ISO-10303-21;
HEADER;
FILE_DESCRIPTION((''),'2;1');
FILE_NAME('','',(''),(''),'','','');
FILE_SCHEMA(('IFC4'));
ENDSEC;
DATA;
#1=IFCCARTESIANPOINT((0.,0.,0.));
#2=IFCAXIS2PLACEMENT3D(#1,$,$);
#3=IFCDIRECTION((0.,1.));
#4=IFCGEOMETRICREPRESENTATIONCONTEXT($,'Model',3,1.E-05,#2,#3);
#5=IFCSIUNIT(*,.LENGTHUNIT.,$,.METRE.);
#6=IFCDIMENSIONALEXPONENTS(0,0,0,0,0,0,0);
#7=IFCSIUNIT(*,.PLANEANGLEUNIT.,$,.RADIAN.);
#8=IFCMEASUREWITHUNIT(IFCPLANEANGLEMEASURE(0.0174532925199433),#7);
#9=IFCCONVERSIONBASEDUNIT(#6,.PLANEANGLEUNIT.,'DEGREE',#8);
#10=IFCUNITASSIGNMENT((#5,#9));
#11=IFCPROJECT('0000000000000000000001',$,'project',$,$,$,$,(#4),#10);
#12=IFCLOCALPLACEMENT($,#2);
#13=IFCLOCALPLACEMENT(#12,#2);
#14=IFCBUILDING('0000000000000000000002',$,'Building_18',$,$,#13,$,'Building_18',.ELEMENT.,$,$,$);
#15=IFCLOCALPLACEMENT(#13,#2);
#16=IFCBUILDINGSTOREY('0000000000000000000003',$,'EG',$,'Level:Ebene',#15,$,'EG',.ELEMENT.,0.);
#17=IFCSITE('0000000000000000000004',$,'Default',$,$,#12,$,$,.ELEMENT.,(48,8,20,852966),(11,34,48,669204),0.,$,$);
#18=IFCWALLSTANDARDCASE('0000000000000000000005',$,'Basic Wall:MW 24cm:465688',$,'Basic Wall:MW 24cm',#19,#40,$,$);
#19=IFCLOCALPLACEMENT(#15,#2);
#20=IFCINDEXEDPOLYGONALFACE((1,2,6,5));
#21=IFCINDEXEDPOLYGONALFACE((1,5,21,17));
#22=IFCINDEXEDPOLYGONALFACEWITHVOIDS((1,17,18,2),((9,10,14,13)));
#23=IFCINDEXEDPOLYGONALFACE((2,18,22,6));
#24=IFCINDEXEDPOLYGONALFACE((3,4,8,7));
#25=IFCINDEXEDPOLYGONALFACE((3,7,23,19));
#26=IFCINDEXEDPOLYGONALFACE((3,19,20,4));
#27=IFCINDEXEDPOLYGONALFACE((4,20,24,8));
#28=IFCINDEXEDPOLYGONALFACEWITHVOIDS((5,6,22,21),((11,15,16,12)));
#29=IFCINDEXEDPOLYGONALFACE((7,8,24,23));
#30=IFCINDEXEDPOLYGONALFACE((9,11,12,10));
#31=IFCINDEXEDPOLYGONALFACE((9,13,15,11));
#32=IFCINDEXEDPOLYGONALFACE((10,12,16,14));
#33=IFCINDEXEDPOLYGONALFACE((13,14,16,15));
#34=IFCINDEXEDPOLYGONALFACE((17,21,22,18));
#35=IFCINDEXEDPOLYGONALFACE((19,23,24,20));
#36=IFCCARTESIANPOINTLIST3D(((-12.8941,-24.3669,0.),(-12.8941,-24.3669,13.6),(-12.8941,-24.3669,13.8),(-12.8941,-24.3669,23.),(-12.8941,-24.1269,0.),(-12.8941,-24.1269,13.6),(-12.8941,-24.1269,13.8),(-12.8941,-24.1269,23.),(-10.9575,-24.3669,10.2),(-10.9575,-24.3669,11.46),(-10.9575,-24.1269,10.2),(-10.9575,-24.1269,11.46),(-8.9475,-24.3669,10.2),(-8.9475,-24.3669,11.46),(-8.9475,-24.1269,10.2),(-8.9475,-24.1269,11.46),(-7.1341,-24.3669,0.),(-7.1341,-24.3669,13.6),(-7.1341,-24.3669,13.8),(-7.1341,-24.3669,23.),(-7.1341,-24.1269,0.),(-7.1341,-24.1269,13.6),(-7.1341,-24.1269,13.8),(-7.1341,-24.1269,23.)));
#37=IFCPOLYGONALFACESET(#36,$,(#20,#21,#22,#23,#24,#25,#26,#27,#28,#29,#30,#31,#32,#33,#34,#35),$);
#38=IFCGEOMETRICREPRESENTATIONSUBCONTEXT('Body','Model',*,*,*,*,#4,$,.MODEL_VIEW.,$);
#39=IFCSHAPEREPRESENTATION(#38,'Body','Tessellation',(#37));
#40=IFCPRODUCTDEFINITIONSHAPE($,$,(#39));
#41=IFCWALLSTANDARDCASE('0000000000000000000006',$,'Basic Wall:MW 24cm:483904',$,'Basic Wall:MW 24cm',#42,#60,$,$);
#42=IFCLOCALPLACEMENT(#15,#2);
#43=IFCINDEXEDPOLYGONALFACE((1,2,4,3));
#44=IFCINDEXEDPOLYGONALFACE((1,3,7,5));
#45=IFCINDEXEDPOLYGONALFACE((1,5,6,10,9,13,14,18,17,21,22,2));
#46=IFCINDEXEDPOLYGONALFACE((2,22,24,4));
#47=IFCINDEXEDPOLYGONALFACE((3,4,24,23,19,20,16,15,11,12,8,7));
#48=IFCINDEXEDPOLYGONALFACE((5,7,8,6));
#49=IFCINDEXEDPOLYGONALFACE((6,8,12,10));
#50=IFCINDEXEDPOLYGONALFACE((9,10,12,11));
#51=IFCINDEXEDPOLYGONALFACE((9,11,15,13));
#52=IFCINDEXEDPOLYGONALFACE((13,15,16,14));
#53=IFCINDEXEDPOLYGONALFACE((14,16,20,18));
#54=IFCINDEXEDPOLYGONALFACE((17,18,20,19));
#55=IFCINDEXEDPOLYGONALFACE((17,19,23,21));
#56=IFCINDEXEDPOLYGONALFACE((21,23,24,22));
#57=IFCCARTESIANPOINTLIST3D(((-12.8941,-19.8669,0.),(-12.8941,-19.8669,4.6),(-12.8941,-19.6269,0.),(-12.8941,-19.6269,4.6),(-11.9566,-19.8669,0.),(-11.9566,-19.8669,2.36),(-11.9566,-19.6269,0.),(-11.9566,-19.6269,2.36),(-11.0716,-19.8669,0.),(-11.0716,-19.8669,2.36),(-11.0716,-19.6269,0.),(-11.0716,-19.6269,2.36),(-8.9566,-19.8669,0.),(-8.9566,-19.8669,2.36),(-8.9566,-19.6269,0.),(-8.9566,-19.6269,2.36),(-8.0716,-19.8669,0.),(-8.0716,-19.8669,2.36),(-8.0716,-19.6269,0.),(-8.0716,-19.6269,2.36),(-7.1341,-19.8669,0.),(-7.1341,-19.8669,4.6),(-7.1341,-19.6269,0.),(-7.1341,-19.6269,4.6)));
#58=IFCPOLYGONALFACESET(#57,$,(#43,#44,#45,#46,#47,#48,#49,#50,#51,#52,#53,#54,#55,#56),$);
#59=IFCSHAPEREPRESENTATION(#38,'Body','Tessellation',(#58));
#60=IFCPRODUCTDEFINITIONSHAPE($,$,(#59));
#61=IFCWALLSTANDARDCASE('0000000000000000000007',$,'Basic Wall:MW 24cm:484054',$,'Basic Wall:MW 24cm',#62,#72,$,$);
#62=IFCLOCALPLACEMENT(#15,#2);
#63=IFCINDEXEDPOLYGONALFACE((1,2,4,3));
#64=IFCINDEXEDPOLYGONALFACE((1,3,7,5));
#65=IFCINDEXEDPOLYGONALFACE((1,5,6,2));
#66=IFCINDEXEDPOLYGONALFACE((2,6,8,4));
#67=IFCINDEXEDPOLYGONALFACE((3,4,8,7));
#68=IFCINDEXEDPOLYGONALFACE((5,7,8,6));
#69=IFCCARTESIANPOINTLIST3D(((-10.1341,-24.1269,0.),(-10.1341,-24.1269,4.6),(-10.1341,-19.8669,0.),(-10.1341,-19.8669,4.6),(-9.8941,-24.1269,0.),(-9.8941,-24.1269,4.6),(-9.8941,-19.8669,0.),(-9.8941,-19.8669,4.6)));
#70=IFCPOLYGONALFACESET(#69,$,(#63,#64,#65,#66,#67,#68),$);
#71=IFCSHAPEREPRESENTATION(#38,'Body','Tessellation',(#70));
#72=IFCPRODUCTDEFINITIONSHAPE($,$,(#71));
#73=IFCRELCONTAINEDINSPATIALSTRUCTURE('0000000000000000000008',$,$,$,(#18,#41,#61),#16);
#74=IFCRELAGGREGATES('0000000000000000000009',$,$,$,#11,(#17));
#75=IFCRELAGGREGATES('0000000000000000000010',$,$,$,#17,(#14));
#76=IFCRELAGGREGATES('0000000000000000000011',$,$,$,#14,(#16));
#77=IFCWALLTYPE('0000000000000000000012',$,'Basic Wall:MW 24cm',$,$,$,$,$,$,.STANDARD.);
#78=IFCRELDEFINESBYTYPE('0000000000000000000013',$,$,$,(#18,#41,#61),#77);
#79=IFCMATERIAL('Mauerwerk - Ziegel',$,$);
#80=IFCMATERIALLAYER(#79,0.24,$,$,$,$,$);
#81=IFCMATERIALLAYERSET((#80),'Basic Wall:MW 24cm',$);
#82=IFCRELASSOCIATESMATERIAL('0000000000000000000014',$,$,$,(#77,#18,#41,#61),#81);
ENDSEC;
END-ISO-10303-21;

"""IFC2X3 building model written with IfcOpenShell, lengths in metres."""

from ifc_helpers import new_model, entity, si_unit, converted_unit, direction, frame, frame_2d, origin, place, context, subcontext, project, spatial, rectangle, extrude, material, layer, layer_set, layer_usage, type_object, element, save


model = new_model("IFC2X3")

# Units and contexts
model_context = context("Model", 3, precision=1e-05, world=origin(), true_north=direction((0.0, 1.0)))
body_context = subcontext(model_context, "Body", "Model", "MODEL_VIEW")
ifc_project = project(units=[si_unit("LENGTHUNIT", "METRE"), converted_unit("PLANEANGLEUNIT", "DEGREE", entity("IfcPlaneAngleMeasure", 0.0174532925199433), si_unit("PLANEANGLEUNIT", "RADIAN"), dimensions=[0, 0, 0, 0, 0, 0, 0])], contexts=[model_context])

# Site, building, storey
site_placement = place(None, origin())
site = spatial("IfcSite", under=ifc_project, at=site_placement, Name="Default", CompositionType="ELEMENT", RefLatitude=(48, 8, 20, 852966), RefLongitude=(11, 34, 48, 669204), RefElevation=0.0)
building_placement = place(site_placement, origin())
building = spatial("IfcBuilding", under=site, at=building_placement, Name="Building_18", LongName="Building_18", CompositionType="ELEMENT")
storey_placement = place(building_placement, origin())
storey = spatial("IfcBuildingStorey", under=building, at=storey_placement, Name="EG", ObjectType="Level:Ebene", LongName="EG", CompositionType="ELEMENT", Elevation=0.0)

# Walls, openings
ifc_material_1 = material(Name="Mauerwerk - Ziegel")
ifc_layer = layer(ifc_material_1, 0.24)
ifc_layer_set = layer_set([ifc_layer], Name="Basic Wall:MW 24cm")
wall_type = type_object("IfcWallType", Name="Basic Wall:MW 24cm", PredefinedType="STANDARD", material=ifc_layer_set)
ifc_layer_usage_1 = layer_usage(ifc_layer_set, "AXIS2", "NEGATIVE", 0.12)
wall_1_placement = place(storey_placement, frame((-12.8941, -24.2469, 0.0)))
wall_1 = element("IfcWallStandardCase", 1, at=wall_1_placement, inside=storey, type_object=wall_type, material=ifc_layer_usage_1, Name="Basic Wall:MW 24cm:465688", ObjectType="Basic Wall:MW 24cm", context=body_context, shape_type="SweptSolid", body=[
    extrude(rectangle(XDim=5.76, YDim=0.24, at=frame_2d((2.88, 0.0), x_axis=(-1.0, 0.0))), origin(), (0.0, 0.0, 1.0), 23.0),
])
opening_1_placement = place(storey_placement, frame((-12.8941, -24.2469, 0.0)))
element("IfcOpeningElement", 2, at=opening_1_placement, cuts=wall_1, ObjectType="Opening", context=body_context, shape_type="SweptSolid", body=[
    extrude(rectangle(XDim=5.76, YDim=0.24, at=frame_2d((0.0, 0.0), x_axis=(1.0, 0.0))), frame((2.88, 0.0, 13.6)), (0.0, 0.0, 1.0), 0.2),
])
opening_2_placement = place(wall_1_placement, frame((3.9465, 0.12, 10.2)))
element("IfcOpeningElement", 3, at=opening_2_placement, cuts=wall_1, ObjectType="Opening", context=body_context, shape_type="SweptSolid", body=[
    extrude(rectangle(XDim=1.26, YDim=2.01, at=frame_2d((0.63, 1.005), x_axis=(1.0, 0.0))), frame((0.0, 0.0, 0.0), z_axis=(0.0, -1.0, 0.0), x_axis=(0.0, 0.0, 1.0)), (0.0, 0.0, 1.0), 0.24),
])
ifc_layer_usage_2 = layer_usage(ifc_layer_set, "AXIS2", "NEGATIVE", 0.12)
wall_2_placement = place(storey_placement, frame((-7.1341, -19.7469, 0.0), z_axis=(0.0, 0.0, 1.0), x_axis=(-1.0, 0.0, 0.0)))
wall_2 = element("IfcWallStandardCase", 4, at=wall_2_placement, inside=storey, type_object=wall_type, material=ifc_layer_usage_2, Name="Basic Wall:MW 24cm:483904", ObjectType="Basic Wall:MW 24cm", context=body_context, shape_type="SweptSolid", body=[
    extrude(rectangle(XDim=5.76, YDim=0.24, at=frame_2d((2.88, 0.0), x_axis=(1.0, 0.0))), origin(), (0.0, 0.0, 1.0), 4.6),
])
opening_3_placement = place(wall_2_placement, frame((3.9375, -0.12, 0.0)))
element("IfcOpeningElement", 5, at=opening_3_placement, cuts=wall_2, ObjectType="Opening", context=body_context, shape_type="SweptSolid", body=[
    extrude(rectangle(XDim=2.36, YDim=0.885, at=frame_2d((1.18, 0.4425), x_axis=(1.0, 0.0))), frame((0.0, 0.0, 0.0), z_axis=(0.0, 1.0, 0.0), x_axis=(0.0, 0.0, 1.0)), (0.0, 0.0, 1.0), 0.24),
])
opening_4_placement = place(wall_2_placement, frame((0.9375, -0.12, 0.0)))
element("IfcOpeningElement", 6, at=opening_4_placement, cuts=wall_2, ObjectType="Opening", context=body_context, shape_type="SweptSolid", body=[
    extrude(rectangle(XDim=2.36, YDim=0.885, at=frame_2d((1.18, 0.4425), x_axis=(1.0, 0.0))), frame((0.0, 0.0, 0.0), z_axis=(0.0, 1.0, 0.0), x_axis=(0.0, 0.0, 1.0)), (0.0, 0.0, 1.0), 0.24),
])

# Wall
ifc_layer_usage_3 = layer_usage(ifc_layer_set, "AXIS2", "NEGATIVE", 0.12)
wall_3_placement = place(storey_placement, frame((-10.0141, -19.8669, 0.0), z_axis=(0.0, 0.0, 1.0), x_axis=(0.0, -1.0, 0.0)))
element("IfcWallStandardCase", 7, at=wall_3_placement, inside=storey, type_object=wall_type, material=ifc_layer_usage_3, Name="Basic Wall:MW 24cm:484054", ObjectType="Basic Wall:MW 24cm", context=body_context, shape_type="SweptSolid", body=[
    extrude(rectangle(XDim=4.26, YDim=0.24, at=frame_2d((2.13, 0.0), x_axis=(-1.0, 0.0))), origin(), (0.0, 0.0, 1.0), 4.6),
])

save(model, "model.ifc")
